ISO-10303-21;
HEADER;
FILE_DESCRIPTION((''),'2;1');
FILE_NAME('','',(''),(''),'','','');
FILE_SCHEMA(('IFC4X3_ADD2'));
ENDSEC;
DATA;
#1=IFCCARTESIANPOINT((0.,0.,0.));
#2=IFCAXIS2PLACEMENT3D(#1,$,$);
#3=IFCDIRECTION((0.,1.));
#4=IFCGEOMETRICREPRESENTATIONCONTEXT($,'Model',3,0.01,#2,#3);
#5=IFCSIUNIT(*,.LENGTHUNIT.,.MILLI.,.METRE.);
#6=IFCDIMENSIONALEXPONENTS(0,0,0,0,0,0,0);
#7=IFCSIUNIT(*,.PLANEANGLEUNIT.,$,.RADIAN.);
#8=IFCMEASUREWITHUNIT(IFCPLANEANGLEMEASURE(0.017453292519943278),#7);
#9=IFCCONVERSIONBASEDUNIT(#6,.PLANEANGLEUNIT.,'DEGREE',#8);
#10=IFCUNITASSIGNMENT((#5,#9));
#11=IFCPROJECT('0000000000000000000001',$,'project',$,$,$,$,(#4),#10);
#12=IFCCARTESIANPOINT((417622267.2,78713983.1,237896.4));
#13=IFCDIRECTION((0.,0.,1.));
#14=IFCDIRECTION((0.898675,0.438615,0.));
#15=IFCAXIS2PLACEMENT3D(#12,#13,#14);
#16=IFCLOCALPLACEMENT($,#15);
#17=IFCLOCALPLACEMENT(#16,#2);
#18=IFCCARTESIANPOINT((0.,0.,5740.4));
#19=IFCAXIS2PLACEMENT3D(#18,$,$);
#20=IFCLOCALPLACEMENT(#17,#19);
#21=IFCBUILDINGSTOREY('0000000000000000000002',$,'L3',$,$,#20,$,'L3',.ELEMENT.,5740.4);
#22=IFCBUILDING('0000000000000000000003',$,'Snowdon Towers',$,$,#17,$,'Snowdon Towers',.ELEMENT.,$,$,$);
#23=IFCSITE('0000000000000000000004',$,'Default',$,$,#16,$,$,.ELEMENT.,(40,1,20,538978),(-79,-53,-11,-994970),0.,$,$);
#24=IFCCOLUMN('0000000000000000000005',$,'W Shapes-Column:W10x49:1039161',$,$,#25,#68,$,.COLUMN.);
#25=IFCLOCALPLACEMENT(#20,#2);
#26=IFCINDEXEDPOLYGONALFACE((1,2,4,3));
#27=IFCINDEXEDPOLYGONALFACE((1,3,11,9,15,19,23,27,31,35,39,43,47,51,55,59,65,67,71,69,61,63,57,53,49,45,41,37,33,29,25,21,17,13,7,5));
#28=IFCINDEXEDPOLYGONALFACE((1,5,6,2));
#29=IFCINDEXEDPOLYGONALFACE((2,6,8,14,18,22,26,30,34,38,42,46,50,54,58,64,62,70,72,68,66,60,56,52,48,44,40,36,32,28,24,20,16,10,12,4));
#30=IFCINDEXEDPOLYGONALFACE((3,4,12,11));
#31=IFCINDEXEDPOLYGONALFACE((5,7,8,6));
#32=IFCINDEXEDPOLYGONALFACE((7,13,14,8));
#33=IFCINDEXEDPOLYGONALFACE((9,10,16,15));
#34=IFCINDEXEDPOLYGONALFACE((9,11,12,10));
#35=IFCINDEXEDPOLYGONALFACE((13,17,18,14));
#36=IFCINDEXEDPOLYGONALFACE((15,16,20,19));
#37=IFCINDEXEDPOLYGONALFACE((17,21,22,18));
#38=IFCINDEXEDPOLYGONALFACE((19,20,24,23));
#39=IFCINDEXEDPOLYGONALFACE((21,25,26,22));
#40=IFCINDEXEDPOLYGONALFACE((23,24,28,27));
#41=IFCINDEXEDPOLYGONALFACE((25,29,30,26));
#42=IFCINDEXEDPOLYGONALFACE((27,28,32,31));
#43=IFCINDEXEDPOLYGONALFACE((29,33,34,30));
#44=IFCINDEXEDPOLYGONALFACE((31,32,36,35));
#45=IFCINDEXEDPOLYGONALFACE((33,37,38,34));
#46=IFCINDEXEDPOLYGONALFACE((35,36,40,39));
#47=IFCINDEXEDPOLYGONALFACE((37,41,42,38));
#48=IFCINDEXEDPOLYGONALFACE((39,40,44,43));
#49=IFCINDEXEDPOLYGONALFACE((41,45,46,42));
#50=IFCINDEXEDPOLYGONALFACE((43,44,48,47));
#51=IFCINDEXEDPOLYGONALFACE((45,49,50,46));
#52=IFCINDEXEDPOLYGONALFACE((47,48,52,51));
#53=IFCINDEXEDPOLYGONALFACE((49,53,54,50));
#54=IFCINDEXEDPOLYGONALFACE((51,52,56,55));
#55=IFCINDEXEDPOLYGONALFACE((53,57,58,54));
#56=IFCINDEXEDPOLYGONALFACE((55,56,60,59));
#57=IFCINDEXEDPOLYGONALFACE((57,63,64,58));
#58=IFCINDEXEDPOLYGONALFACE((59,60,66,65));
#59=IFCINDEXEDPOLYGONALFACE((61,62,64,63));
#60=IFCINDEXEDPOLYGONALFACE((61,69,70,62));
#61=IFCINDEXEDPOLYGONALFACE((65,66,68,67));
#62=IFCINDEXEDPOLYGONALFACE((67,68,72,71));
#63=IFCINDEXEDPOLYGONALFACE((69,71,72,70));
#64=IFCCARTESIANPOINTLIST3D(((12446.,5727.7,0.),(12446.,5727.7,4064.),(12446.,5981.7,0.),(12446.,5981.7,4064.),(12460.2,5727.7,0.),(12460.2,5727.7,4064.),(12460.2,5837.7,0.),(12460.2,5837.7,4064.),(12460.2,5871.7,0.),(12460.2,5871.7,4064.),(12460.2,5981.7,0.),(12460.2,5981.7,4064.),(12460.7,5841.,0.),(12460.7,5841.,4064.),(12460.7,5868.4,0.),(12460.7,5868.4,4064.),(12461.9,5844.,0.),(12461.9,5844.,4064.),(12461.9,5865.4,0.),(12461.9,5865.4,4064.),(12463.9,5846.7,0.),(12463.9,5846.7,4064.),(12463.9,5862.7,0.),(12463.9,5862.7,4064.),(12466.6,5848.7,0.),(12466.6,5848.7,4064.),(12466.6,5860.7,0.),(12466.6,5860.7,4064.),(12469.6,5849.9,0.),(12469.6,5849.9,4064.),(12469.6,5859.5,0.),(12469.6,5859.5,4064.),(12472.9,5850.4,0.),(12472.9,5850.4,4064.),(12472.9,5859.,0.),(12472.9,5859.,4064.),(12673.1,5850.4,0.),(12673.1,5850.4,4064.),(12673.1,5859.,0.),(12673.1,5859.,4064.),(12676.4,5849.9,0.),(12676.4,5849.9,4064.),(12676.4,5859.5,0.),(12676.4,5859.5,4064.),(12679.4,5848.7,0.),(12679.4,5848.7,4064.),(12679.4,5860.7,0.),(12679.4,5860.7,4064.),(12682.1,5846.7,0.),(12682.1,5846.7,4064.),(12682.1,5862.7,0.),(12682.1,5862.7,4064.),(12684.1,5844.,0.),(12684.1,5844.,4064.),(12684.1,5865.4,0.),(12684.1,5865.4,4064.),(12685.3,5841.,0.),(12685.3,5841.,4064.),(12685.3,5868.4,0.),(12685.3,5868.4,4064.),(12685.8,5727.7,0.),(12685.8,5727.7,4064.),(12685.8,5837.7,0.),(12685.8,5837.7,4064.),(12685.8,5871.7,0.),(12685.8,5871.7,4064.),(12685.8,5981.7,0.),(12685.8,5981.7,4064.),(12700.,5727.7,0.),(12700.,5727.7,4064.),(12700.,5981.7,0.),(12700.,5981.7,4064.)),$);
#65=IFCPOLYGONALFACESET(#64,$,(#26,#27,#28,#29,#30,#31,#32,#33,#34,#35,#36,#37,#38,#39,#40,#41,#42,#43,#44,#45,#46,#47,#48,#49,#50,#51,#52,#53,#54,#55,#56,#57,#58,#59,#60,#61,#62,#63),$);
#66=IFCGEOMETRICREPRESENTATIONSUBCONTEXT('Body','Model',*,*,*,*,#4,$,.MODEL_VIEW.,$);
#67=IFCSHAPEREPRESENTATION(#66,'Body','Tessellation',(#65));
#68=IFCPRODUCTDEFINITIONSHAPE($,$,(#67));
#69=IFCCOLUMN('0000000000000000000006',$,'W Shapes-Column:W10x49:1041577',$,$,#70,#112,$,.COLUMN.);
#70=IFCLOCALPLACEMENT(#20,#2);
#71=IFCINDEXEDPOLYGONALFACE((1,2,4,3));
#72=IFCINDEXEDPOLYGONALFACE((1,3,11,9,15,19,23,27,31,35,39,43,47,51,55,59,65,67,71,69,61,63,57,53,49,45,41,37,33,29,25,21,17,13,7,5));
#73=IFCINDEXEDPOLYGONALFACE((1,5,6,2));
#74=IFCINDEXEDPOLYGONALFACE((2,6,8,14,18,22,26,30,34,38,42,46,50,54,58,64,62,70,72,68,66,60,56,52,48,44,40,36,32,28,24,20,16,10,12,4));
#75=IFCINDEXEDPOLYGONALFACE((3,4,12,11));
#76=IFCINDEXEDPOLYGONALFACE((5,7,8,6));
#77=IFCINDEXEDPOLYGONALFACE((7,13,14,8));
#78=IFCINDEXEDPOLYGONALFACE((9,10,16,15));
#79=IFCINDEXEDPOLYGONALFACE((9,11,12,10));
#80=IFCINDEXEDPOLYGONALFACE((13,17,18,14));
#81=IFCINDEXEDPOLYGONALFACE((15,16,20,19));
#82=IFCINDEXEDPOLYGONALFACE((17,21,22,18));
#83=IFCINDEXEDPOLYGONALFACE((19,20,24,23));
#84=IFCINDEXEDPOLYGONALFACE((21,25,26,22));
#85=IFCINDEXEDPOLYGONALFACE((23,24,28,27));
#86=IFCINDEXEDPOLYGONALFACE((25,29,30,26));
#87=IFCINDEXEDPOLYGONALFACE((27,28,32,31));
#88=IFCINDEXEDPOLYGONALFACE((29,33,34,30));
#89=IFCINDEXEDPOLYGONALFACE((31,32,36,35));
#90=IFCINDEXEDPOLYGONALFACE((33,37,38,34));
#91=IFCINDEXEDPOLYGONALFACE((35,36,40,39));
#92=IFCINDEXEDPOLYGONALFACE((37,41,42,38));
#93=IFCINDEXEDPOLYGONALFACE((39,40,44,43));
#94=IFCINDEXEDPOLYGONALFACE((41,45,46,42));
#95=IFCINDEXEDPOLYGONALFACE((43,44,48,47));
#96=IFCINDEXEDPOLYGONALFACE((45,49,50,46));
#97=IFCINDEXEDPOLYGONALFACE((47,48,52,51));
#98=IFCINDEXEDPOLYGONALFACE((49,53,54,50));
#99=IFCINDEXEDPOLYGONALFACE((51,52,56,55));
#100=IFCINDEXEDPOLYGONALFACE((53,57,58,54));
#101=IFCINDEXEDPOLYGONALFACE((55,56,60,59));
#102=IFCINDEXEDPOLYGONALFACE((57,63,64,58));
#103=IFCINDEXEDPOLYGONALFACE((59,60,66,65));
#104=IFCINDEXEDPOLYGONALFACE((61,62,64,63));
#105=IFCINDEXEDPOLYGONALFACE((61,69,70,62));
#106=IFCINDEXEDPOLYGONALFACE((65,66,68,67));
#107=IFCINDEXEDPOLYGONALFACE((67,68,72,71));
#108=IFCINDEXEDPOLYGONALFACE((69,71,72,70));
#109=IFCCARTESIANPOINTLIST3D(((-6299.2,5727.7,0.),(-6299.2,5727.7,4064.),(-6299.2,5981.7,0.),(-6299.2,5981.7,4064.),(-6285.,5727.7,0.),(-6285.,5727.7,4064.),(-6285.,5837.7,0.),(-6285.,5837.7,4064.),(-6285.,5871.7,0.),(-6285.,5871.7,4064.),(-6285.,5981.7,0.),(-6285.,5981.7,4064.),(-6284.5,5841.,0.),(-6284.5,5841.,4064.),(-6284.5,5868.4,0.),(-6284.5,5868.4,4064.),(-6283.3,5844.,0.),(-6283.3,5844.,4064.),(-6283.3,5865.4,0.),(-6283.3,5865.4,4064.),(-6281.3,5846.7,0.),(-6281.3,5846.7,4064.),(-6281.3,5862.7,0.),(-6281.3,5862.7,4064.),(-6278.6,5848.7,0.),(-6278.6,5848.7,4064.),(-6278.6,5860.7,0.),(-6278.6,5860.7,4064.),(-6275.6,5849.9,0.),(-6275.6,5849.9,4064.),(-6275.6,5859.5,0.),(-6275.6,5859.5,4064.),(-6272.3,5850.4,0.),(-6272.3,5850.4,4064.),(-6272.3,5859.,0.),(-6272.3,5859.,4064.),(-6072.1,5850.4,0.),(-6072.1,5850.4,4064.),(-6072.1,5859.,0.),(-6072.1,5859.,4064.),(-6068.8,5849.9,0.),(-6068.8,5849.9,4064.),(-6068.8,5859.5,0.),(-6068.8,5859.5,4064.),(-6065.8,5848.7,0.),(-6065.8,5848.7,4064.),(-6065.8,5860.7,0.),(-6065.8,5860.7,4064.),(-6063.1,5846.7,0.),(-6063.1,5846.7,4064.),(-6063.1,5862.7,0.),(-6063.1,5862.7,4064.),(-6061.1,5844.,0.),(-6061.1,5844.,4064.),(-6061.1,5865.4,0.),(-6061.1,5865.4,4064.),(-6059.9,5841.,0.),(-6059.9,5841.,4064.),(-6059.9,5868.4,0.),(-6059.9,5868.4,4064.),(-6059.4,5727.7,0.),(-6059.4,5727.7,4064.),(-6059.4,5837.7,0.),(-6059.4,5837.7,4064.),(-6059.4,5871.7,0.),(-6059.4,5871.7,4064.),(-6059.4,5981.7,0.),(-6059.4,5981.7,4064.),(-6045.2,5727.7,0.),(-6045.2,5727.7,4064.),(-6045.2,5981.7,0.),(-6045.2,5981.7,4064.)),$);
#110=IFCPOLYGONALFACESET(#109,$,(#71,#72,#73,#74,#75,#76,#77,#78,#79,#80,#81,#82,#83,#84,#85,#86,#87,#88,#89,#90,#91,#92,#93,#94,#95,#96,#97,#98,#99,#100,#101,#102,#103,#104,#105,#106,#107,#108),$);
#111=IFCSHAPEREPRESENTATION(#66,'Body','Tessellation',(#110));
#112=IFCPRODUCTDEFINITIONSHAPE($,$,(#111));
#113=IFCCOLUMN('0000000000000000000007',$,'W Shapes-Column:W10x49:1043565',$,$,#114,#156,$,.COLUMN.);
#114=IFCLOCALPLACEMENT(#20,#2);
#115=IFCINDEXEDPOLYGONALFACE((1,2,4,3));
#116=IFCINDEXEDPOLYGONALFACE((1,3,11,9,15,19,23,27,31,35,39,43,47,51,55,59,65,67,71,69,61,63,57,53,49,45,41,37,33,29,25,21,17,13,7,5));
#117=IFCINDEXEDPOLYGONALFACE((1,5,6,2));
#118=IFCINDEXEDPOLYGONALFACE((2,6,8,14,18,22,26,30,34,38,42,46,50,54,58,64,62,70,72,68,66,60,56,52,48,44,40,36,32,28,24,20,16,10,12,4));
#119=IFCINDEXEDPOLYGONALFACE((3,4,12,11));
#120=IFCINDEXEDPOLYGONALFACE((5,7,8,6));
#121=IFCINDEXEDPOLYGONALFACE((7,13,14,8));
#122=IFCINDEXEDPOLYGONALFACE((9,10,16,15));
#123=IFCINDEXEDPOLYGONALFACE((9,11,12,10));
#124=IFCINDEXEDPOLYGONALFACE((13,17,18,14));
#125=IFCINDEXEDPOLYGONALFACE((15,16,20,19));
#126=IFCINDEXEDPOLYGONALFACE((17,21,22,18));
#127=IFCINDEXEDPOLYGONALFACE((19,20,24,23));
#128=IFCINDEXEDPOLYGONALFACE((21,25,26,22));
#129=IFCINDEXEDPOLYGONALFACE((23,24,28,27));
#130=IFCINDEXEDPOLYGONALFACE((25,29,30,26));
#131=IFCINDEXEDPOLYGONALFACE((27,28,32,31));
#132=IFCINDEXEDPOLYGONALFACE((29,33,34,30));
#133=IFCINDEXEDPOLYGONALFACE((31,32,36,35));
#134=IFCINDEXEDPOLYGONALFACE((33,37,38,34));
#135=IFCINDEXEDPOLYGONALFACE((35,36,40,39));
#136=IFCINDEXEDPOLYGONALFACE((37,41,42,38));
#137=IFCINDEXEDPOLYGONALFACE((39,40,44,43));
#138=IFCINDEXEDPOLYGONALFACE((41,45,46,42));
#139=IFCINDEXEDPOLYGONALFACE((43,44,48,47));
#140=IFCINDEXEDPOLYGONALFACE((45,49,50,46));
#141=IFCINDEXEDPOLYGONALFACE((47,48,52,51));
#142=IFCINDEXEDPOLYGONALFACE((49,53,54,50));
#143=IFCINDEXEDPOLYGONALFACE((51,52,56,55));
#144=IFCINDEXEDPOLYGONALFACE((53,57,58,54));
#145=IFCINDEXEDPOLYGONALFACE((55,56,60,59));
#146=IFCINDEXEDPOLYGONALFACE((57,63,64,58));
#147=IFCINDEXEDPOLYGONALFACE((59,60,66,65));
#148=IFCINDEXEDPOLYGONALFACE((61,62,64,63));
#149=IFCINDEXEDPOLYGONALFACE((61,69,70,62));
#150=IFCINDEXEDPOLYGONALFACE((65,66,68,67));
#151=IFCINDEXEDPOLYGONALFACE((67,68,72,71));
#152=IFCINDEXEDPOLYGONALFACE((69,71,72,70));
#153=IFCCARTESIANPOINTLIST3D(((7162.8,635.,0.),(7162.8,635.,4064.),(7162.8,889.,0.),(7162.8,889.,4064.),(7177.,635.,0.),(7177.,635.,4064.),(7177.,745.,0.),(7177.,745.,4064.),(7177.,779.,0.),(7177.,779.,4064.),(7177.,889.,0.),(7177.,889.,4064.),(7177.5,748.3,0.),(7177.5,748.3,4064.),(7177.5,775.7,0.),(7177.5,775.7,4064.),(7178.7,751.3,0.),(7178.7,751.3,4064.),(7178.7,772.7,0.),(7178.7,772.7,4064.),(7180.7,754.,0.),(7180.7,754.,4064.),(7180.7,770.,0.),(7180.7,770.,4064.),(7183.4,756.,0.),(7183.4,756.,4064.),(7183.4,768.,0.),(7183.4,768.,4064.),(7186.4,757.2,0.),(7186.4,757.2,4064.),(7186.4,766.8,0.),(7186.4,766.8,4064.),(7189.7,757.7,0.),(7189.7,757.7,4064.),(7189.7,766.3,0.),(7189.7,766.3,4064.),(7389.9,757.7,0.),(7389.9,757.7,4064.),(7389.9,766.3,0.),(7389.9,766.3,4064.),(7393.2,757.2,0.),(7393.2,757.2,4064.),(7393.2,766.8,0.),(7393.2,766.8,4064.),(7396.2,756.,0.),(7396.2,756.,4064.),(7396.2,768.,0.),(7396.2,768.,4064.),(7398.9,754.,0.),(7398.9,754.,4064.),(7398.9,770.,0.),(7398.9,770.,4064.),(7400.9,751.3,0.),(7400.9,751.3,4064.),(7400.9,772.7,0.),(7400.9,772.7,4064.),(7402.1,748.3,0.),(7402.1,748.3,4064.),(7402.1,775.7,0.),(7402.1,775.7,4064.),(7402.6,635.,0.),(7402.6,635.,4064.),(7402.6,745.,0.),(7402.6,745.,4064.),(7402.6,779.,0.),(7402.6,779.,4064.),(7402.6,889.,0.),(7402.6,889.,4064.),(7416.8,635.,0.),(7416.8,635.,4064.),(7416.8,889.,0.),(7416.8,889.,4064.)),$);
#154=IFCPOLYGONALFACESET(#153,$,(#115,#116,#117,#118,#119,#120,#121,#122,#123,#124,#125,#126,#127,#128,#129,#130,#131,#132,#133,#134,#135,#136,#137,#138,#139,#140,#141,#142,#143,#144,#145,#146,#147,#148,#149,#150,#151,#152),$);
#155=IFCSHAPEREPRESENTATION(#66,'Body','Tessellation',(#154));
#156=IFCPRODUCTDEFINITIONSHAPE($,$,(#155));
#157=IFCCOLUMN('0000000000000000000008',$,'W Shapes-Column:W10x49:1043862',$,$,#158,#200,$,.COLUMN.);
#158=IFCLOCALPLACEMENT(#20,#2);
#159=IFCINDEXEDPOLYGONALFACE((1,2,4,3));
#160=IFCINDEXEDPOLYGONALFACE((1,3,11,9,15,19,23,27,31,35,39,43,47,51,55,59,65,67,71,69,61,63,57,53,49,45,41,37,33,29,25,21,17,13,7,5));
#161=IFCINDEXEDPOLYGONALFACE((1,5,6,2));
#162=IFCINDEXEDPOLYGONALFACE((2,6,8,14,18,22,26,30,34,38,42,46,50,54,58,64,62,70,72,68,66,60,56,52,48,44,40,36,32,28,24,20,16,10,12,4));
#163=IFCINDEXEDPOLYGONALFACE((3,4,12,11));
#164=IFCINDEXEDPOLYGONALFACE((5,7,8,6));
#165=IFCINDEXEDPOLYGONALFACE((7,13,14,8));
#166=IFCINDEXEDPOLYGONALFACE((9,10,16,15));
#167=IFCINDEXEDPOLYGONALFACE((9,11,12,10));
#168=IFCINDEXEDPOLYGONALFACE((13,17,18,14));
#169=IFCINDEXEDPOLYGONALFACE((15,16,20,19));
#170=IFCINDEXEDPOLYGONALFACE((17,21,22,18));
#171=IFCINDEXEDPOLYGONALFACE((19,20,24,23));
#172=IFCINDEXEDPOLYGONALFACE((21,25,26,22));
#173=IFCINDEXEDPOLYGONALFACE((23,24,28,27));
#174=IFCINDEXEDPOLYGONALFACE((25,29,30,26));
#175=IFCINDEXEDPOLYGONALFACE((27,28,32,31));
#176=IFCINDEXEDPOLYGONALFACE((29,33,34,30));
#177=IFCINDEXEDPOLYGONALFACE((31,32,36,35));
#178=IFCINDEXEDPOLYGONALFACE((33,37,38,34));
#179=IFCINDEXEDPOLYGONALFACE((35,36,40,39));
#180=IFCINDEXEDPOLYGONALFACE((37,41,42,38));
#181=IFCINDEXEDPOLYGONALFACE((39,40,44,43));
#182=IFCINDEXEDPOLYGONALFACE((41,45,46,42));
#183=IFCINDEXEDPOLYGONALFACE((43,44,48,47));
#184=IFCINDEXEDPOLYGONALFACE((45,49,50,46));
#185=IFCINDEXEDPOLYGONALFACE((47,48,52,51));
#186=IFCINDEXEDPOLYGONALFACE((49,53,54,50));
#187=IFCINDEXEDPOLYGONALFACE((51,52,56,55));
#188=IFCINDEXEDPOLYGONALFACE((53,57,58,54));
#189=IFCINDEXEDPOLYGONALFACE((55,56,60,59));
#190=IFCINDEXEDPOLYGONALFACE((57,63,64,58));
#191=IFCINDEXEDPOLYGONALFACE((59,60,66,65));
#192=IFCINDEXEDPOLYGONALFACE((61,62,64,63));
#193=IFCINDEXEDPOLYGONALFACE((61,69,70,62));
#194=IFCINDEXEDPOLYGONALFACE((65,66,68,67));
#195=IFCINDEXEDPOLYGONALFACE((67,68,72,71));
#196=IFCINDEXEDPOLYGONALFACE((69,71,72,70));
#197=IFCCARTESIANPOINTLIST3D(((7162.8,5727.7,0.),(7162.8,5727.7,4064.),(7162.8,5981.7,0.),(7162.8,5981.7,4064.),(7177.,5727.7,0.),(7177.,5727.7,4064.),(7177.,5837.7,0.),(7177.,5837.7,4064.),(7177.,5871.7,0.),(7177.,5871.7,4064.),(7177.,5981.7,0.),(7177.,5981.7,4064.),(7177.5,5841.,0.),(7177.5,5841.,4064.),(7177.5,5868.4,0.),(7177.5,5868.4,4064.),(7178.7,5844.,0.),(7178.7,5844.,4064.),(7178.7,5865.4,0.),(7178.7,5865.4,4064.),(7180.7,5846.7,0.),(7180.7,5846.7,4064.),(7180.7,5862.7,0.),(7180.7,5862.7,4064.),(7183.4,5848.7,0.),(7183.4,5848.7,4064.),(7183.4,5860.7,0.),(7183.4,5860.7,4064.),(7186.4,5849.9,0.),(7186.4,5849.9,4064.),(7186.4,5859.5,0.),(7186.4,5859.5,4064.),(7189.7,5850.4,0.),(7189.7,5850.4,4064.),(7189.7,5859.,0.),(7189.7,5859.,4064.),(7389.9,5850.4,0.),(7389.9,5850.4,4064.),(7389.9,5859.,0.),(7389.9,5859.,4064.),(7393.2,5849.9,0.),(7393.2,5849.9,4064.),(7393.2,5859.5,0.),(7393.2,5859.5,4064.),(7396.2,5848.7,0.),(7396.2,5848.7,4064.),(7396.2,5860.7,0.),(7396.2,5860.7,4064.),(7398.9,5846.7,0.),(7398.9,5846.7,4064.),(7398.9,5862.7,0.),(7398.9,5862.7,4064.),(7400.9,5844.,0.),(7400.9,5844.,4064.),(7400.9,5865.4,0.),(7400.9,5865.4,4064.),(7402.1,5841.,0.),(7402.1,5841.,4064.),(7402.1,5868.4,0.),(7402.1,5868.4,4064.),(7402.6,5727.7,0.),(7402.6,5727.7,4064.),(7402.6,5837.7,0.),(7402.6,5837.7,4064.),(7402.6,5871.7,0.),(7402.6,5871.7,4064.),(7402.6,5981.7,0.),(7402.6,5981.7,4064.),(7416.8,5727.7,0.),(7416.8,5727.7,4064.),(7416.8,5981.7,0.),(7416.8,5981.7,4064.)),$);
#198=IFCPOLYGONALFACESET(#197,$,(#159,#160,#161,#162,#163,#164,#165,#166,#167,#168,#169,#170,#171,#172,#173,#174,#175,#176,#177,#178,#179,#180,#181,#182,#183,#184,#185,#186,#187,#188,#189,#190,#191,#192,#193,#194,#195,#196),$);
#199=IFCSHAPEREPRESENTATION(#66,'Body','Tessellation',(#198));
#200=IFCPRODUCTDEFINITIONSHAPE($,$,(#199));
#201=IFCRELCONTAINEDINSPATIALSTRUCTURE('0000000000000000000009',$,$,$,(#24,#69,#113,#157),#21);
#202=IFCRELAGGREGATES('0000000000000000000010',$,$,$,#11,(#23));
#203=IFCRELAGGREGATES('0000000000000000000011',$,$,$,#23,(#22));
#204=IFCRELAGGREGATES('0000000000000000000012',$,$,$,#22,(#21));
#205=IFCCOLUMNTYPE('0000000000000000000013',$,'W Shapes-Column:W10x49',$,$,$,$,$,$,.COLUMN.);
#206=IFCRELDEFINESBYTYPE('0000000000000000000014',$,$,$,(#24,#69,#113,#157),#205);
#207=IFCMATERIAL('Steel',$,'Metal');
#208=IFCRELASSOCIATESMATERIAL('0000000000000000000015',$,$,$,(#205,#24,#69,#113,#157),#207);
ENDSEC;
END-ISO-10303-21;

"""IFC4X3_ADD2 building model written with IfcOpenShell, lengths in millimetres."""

from ifc_helpers import new_model, entity, si_unit, converted_unit, direction, frame, frame_2d, origin, place, context, subcontext, project, spatial, i_section, extrude, source, transform, mapped, material, material_profile, profile_set, profile_usage, type_object, type_shapes, element, save


model = new_model("IFC4X3_ADD2")

# Units and contexts
model_context = context("Model", 3, precision=0.01, world=origin(), true_north=direction((0.0, 1.0)))
body_context = subcontext(model_context, "Body", "Model", "MODEL_VIEW")
ifc_project = project(units=[si_unit("LENGTHUNIT", "METRE", prefix="MILLI"), converted_unit("PLANEANGLEUNIT", "DEGREE", entity("IfcPlaneAngleMeasure", 0.017453292519943278), si_unit("PLANEANGLEUNIT", "RADIAN"), dimensions=[0, 0, 0, 0, 0, 0, 0])], contexts=[model_context])

# Site, building, storey
site_placement = place(None, frame((417622267.2, 78713983.1, 237896.4), z_axis=(0.0, 0.0, 1.0), x_axis=(0.898675, 0.438615, 0.0)))
site = spatial("IfcSite", under=ifc_project, at=site_placement, Name="Default", CompositionType="ELEMENT", RefLatitude=(40, 1, 20, 538978), RefLongitude=(-79, -53, -11, -994970), RefElevation=0.0)
building_placement = place(site_placement, origin())
building = spatial("IfcBuilding", under=site, at=building_placement, Name="Snowdon Towers", LongName="Snowdon Towers", CompositionType="ELEMENT")
storey_placement = place(building_placement, frame((0.0, 0.0, 5740.4)))
storey = spatial("IfcBuildingStorey", under=building, at=storey_placement, Name="L3", LongName="L3", CompositionType="ELEMENT", Elevation=5740.4)

# Columns
ifc_material_1 = material(Name="Steel", Category="Metal")
ifc_material_profile_1 = material_profile(ifc_material_1, i_section(OverallWidth=254.0, OverallDepth=254.0, WebThickness=8.6, FlangeThickness=14.2, FilletRadius=12.7, at=frame_2d((0.0, 0.0), x_axis=(1.0, 0.0))), Name="W10x49")
ifc_profile_set_1 = profile_set([ifc_material_profile_1], Name="W10x49")
ifc_profile_usage_1 = profile_usage(ifc_profile_set_1)
column_type_1 = type_object("IfcColumnType", Name="W Shapes-Column:W10x49", PredefinedType="COLUMN", material=ifc_profile_set_1)
shared_shape_1 = source(origin(), body_context, "Body", "SweptSolid", [
    extrude(i_section(OverallWidth=254.0, OverallDepth=254.0, WebThickness=8.6, FlangeThickness=14.2, FilletRadius=12.7, at=frame_2d((0.0, 0.0), x_axis=(1.0, 0.0))), frame((0.0, 0.0, 5740.4), z_axis=(0.0, 0.0, 1.0), x_axis=(-1.0, 0.0, 0.0)), (0.0, 0.0, 1.0), 4064.0),
])
type_shapes(column_type_1, [shared_shape_1])
for number, where, z_axis, x_axis, name in (
    (1, (12573.0, 5854.7, -5740.4), (0.0, 0.0, 1.0), (0.0, 1.0, 0.0), "W Shapes-Column:W10x49:1039161"),
    (2, (-6172.2, 5854.7, -5740.4), (0.0, 0.0, 1.0), (0.0, 1.0, 0.0), "W Shapes-Column:W10x49:1041577"),
    (3, (7289.8, 762.0, -5740.4), (0.0, 0.0, 1.0), (0.0, 1.0, 0.0), "W Shapes-Column:W10x49:1043565"),
    (4, (7289.8, 5854.7, -5740.4), (0.0, 0.0, 1.0), (0.0, 1.0, 0.0), "W Shapes-Column:W10x49:1043862"),
):
    element("IfcColumn", number, at=place(storey_placement, frame(where, z_axis=z_axis, x_axis=x_axis)), inside=storey, type_object=column_type_1, material=ifc_profile_usage_1, Name=name, PredefinedType="COLUMN", context=body_context, shape_type="MappedRepresentation", body=[
        mapped(shared_shape_1, transform((0.0, 0.0, 0.0), scale=1.0)),
    ])

save(model, "model.ifc")
